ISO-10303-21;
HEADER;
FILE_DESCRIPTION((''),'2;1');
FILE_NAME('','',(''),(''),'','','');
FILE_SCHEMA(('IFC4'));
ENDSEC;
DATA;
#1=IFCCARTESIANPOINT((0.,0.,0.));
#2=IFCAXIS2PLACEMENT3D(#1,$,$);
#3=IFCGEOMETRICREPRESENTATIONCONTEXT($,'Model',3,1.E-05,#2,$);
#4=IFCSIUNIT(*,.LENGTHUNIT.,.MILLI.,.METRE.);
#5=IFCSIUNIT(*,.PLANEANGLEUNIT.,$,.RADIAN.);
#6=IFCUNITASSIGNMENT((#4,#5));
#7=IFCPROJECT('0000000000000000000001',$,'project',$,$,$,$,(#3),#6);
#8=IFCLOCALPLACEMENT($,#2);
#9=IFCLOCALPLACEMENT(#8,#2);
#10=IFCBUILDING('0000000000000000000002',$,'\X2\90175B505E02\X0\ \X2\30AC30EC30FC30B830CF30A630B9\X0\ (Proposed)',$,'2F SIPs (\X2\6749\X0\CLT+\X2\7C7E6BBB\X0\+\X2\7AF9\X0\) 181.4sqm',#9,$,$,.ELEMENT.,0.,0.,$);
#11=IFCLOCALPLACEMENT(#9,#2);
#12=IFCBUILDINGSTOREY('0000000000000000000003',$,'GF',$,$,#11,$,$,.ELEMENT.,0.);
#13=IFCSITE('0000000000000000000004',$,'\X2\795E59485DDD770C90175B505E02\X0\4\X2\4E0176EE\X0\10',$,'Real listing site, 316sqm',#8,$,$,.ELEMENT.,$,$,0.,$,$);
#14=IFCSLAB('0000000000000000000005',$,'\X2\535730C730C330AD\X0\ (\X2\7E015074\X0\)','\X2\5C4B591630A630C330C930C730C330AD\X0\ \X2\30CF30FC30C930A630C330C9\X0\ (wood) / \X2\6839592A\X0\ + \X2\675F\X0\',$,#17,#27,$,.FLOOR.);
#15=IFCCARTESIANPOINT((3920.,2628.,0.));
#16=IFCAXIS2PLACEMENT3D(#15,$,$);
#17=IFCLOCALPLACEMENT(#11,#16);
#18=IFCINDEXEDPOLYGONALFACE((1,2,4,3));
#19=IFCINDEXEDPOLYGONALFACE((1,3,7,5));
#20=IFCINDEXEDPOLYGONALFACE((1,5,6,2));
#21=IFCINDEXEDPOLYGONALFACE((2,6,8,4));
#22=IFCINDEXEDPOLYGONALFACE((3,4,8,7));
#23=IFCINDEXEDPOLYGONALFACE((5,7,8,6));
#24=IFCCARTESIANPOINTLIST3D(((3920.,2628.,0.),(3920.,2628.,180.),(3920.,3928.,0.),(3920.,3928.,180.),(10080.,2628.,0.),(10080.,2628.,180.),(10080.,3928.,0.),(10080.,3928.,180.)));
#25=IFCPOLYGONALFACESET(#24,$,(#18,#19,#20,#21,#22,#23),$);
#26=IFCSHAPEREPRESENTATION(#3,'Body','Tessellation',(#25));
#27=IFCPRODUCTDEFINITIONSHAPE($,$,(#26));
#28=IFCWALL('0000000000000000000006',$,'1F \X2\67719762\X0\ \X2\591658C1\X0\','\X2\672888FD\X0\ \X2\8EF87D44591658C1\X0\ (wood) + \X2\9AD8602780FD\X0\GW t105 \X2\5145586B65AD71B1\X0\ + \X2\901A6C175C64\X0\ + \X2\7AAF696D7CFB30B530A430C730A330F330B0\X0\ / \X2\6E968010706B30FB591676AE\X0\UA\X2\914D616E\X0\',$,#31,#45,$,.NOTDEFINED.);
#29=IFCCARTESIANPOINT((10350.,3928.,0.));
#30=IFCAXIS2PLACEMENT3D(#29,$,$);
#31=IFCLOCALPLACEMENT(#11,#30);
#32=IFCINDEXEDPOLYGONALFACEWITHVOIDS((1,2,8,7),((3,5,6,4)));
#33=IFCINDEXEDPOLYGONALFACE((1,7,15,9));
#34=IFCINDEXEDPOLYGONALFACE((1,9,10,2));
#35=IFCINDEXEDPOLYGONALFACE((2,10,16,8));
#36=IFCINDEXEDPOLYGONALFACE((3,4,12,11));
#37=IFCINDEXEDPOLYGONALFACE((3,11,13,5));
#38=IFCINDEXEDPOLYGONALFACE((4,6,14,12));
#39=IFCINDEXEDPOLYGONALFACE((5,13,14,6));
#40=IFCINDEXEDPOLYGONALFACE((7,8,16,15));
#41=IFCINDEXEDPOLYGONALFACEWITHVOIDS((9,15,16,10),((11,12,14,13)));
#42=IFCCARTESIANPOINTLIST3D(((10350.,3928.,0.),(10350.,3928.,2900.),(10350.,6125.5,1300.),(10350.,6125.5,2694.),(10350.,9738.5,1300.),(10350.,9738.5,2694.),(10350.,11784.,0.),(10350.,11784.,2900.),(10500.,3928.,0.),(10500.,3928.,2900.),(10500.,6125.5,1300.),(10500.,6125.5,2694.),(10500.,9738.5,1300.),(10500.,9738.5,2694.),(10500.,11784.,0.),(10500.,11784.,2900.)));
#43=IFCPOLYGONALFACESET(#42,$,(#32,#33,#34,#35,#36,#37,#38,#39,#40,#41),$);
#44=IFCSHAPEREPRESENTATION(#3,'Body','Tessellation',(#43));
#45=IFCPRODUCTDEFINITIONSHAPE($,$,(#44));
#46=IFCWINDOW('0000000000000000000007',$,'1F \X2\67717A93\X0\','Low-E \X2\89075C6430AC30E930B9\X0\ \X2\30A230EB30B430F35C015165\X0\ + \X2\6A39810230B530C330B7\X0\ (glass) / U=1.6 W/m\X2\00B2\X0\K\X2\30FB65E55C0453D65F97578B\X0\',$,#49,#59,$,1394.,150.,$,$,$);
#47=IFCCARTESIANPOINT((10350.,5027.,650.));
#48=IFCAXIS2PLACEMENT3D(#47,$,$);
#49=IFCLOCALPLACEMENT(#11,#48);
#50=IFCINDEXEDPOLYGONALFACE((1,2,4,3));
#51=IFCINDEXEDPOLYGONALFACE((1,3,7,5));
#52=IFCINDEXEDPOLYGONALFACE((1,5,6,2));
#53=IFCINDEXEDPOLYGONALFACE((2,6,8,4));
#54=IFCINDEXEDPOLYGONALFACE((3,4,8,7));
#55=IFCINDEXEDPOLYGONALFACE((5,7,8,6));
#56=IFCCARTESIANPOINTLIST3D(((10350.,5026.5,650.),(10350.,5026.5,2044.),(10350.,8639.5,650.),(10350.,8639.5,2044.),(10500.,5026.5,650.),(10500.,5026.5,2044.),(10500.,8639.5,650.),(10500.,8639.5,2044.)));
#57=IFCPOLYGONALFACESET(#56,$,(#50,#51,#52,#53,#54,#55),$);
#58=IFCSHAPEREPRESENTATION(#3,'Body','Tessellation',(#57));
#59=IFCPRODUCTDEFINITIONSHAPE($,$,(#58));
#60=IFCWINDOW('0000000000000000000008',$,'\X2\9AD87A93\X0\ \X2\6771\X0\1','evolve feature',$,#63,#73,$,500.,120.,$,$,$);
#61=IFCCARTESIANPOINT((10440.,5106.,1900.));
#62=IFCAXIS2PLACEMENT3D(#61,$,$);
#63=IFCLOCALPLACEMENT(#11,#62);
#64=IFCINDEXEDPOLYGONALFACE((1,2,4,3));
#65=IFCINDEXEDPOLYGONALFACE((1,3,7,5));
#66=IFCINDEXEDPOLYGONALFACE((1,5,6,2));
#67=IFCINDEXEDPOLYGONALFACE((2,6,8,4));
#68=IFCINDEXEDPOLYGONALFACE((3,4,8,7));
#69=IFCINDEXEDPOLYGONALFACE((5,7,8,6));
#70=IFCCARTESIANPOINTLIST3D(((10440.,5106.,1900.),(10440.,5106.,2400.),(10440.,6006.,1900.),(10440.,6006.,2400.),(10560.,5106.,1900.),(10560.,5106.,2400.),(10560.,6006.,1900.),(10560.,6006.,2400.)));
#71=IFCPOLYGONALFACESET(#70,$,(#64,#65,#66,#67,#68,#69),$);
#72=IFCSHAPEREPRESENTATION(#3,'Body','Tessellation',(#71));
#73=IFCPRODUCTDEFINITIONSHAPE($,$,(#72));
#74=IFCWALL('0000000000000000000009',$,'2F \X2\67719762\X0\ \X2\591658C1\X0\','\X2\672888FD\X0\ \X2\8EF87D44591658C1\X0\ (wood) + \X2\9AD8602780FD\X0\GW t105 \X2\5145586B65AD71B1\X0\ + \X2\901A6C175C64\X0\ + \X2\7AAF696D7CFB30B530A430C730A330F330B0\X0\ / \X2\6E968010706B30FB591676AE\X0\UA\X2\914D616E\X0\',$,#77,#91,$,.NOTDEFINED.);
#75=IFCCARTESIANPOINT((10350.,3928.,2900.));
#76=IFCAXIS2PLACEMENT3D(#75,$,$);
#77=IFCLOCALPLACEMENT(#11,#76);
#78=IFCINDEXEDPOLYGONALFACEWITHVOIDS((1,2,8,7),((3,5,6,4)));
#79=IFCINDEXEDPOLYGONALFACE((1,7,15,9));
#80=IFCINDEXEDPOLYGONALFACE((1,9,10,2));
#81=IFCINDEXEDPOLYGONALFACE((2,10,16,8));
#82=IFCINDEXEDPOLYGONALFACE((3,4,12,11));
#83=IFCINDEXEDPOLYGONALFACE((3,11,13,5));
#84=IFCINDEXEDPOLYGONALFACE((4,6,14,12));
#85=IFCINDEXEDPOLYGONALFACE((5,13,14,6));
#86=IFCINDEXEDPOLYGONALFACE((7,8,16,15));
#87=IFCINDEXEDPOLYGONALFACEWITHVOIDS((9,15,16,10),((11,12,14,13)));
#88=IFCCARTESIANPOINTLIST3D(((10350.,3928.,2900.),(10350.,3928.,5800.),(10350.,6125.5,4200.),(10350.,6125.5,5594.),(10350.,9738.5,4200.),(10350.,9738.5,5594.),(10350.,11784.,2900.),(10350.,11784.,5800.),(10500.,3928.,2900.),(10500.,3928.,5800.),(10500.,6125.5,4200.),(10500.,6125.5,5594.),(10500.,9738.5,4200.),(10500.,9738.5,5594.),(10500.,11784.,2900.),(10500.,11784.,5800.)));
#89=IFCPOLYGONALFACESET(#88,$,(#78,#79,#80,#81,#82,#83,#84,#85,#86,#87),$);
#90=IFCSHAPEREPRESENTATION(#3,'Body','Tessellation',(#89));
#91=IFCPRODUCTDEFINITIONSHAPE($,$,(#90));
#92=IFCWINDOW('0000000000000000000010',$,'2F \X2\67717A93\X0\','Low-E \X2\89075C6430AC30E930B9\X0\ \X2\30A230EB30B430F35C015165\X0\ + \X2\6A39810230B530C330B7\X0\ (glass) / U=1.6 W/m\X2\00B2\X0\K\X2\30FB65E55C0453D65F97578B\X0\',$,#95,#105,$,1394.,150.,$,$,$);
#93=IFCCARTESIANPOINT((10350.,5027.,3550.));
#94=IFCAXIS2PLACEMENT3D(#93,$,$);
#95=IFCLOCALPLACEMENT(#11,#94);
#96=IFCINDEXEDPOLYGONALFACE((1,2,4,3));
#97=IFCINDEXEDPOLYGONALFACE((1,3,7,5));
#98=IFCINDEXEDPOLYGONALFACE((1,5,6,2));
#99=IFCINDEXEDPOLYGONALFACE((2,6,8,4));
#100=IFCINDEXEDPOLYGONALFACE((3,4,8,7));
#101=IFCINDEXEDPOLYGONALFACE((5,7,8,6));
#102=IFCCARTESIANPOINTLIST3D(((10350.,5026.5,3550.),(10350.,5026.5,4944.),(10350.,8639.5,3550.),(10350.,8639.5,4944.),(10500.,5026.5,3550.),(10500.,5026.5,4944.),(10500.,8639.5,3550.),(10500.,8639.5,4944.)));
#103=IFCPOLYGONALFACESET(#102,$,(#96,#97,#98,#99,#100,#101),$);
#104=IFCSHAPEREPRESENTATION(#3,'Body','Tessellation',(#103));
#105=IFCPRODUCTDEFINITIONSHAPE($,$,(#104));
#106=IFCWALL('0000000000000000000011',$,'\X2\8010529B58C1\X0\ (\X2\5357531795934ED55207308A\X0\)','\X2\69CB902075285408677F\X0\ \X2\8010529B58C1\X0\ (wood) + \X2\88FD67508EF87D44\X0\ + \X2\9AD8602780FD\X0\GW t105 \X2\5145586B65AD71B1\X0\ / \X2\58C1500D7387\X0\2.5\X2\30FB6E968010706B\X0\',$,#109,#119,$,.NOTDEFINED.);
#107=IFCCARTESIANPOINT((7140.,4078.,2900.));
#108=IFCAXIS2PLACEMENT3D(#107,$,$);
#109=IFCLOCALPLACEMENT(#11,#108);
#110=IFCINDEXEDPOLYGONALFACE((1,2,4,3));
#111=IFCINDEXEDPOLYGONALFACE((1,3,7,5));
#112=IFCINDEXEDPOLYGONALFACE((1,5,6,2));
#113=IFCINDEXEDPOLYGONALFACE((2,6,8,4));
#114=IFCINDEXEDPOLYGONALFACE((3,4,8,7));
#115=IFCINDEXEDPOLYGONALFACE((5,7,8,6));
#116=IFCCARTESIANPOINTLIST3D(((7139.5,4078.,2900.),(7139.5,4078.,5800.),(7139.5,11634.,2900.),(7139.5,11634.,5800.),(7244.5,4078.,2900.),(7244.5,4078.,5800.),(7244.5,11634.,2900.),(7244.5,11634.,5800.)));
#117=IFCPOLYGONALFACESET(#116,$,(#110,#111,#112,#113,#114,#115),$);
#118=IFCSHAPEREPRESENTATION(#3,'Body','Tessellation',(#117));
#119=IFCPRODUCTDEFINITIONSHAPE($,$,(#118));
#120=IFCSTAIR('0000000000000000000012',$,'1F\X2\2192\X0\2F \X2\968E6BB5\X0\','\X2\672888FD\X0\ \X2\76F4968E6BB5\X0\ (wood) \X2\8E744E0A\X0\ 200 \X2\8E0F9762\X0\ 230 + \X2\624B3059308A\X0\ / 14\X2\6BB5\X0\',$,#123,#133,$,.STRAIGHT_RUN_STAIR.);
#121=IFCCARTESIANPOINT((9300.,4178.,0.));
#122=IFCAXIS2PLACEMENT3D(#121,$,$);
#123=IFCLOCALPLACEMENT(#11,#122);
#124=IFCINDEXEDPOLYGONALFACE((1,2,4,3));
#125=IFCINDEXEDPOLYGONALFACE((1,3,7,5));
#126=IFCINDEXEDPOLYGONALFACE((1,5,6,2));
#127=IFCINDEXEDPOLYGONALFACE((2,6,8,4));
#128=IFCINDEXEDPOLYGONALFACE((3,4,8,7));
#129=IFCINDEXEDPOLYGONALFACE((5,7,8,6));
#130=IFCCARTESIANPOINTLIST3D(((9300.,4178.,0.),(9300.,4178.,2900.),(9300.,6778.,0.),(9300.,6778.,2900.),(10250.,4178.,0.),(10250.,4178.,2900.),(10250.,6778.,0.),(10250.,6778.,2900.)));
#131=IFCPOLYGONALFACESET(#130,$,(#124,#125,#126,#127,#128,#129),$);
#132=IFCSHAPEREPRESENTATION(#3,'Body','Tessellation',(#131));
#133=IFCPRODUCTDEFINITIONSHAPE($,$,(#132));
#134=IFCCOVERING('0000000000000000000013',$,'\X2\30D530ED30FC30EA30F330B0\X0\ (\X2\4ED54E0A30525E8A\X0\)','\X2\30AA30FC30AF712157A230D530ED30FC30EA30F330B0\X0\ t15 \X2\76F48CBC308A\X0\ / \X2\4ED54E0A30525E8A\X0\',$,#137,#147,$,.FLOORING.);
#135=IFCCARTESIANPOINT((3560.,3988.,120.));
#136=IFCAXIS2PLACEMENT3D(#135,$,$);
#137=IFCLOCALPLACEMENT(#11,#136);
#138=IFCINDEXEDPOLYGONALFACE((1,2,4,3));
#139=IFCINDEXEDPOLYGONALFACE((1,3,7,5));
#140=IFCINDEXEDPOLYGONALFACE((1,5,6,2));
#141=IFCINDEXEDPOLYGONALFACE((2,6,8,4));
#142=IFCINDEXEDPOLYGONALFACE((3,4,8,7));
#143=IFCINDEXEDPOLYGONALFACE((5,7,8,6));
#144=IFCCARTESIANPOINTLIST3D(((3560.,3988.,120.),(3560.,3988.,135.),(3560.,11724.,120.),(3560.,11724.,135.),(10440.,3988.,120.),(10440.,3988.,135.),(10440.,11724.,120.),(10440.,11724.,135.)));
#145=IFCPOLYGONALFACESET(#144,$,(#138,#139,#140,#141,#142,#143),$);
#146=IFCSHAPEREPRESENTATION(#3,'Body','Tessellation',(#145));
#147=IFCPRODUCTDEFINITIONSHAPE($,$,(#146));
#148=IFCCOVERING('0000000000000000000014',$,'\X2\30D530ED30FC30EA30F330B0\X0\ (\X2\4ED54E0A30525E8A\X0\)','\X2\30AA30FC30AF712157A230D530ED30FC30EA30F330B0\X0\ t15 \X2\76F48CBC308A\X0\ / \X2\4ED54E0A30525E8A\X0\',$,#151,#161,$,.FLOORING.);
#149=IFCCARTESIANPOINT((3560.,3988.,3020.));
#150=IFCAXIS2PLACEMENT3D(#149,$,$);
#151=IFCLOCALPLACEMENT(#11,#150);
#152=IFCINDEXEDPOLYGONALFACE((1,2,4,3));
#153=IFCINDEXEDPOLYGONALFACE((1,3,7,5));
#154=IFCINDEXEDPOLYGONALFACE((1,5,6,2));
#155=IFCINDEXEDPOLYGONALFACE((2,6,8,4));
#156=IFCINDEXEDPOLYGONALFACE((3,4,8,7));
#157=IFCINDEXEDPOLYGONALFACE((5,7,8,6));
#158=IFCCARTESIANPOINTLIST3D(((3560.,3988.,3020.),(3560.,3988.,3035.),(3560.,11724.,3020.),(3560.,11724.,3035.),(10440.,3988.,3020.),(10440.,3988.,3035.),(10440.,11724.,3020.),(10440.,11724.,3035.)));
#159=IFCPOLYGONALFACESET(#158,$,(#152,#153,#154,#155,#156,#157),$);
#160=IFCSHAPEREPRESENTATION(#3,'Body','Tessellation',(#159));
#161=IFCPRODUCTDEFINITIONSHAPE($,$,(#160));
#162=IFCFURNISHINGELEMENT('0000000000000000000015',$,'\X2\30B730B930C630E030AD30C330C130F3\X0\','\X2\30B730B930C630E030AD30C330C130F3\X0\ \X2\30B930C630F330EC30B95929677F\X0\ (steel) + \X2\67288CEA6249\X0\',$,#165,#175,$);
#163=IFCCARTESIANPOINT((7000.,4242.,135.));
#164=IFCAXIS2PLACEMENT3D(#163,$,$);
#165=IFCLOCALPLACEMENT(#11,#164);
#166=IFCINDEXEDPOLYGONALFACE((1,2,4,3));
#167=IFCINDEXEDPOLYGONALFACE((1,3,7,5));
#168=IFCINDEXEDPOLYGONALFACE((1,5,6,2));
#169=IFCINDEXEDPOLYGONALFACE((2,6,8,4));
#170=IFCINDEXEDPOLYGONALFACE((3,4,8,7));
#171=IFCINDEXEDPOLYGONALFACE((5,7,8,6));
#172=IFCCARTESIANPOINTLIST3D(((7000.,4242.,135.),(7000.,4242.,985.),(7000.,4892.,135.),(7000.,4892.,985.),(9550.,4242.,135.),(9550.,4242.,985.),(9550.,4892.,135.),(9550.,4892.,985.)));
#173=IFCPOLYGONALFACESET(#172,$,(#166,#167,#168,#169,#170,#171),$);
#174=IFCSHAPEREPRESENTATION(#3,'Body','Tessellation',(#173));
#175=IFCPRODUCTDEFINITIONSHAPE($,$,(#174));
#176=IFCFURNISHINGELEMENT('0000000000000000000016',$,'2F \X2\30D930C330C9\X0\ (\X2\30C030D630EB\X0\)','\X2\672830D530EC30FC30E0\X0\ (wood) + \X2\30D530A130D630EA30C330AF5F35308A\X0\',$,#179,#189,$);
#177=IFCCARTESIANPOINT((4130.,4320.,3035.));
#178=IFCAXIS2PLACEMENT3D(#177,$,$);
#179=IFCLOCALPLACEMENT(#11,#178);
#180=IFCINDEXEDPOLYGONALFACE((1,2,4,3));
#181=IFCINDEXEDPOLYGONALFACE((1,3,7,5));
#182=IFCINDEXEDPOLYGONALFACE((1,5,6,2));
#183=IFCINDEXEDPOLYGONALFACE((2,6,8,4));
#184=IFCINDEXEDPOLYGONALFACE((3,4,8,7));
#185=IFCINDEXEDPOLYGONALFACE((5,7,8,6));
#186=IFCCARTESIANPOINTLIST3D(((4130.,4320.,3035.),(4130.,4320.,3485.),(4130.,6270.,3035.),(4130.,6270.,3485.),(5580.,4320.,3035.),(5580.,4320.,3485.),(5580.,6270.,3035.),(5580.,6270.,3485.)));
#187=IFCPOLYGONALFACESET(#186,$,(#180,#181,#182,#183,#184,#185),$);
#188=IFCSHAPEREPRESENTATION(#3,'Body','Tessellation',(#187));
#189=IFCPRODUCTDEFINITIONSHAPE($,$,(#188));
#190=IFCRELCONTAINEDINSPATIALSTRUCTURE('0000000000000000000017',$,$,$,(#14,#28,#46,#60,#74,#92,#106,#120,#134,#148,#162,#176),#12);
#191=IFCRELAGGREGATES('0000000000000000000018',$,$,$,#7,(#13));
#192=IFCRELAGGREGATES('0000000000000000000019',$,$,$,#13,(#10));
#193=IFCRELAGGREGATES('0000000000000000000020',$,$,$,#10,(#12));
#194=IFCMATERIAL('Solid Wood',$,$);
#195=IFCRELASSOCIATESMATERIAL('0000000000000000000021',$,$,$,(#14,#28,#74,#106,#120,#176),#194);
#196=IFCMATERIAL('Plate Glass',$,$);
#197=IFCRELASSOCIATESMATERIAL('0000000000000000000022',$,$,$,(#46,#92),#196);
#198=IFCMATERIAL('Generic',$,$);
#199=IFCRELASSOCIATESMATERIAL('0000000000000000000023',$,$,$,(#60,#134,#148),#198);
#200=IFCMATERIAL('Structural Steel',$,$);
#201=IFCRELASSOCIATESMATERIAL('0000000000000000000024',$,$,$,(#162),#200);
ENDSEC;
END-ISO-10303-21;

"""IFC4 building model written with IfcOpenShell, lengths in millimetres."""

from ifc_helpers import new_model, si_unit, frame, frame_2d, origin, place, context, project, spatial, rectangle, extrude, material, element, fill, save


model = new_model("IFC4")

# Units and contexts
model_context = context("Model", 3, precision=1e-05, world=origin())
ifc_project = project(units=[si_unit("LENGTHUNIT", "METRE", prefix="MILLI"), si_unit("PLANEANGLEUNIT", "RADIAN")], contexts=[model_context])

# Site, building, storey
site_placement = place(None, origin())
site = spatial("IfcSite", under=ifc_project, at=site_placement, Name="神奈川県逗子市4丁目10", ObjectType="Real listing site, 316sqm", CompositionType="ELEMENT", RefElevation=0.0)
building_placement = place(site_placement, origin())
building = spatial("IfcBuilding", under=site, at=building_placement, Name="逗子市 ガレージハウス (Proposed)", ObjectType="2F SIPs (杉CLT+籾殻+竹) 181.4sqm", CompositionType="ELEMENT", ElevationOfRefHeight=0.0, ElevationOfTerrain=0.0)
storey_placement = place(building_placement, origin())
storey = spatial("IfcBuildingStorey", under=building, at=storey_placement, Name="GF", CompositionType="ELEMENT", Elevation=0.0)

# Slab
ifc_material_1 = material(Name="Solid Wood")
slab_placement = place(storey_placement, frame((3920.0, 2628.0, 0.0)))
element("IfcSlab", 1, at=slab_placement, inside=storey, material=ifc_material_1, Name="南デッキ (縁側)", Description="屋外ウッドデッキ ハードウッド (wood) / 根太 + 束", PredefinedType="FLOOR", context=model_context, shape_type="SweptSolid", body=[
    extrude(rectangle(XDim=6160.0, YDim=1300.0, at=frame_2d((3080.0, 650.0))), frame((3920.0, 2628.0, 0.0)), (0.0, 0.0, 1.0), 180.0),
])

# Wall, openings, windows
wall_1_placement = place(storey_placement, frame((10350.0, 3928.0, 0.0)))
wall_1 = element("IfcWall", 2, at=wall_1_placement, inside=storey, material=ifc_material_1, Name="1F 東面 外壁", Description="木製 軸組外壁 (wood) + 高性能GW t105 充填断熱 + 通気層 + 窯業系サイディング / 準耐火・外皮UA配慮", PredefinedType="NOTDEFINED", context=model_context, shape_type="SweptSolid", body=[
    extrude(rectangle(XDim=150.0, YDim=7856.0, at=frame_2d((75.0, 3928.0))), frame((10350.0, 3928.0, 0.0)), (0.0, 0.0, 1.0), 2900.0),
])
opening_1_placement = place(storey_placement, frame((10350.0, 5027.0, 650.0)))
opening_1 = element("IfcOpeningElement", 3, at=opening_1_placement, cuts=wall_1, PredefinedType="NOTDEFINED", context=model_context, shape_type="SweptSolid", body=[
    extrude(rectangle(XDim=150.0, YDim=3613.0, at=frame_2d((75.0, 1806.0))), frame((10350.0, 5027.0, 650.0)), (0.0, 0.0, 1.0), 1394.0),
])
opening_2_placement = place(storey_placement, frame((10440.0, 5106.0, 1900.0)))
opening_2 = element("IfcOpeningElement", 4, at=opening_2_placement, cuts=wall_1, PredefinedType="NOTDEFINED", context=model_context, shape_type="SweptSolid", body=[
    extrude(rectangle(XDim=120.0, YDim=900.0, at=frame_2d((60.0, 450.0))), frame((10440.0, 5106.0, 1900.0)), (0.0, 0.0, 1.0), 500.0),
])
ifc_material_2 = material(Name="Plate Glass")
window_1_placement = place(storey_placement, frame((10350.0, 5027.0, 650.0)))
window_1 = element("IfcWindow", 5, at=window_1_placement, inside=storey, material=ifc_material_2, Name="1F 東窓", Description="Low-E 複層ガラス アルゴン封入 + 樹脂サッシ (glass) / U=1.6 W/m²K・日射取得型", OverallHeight=1394.0, OverallWidth=150.0, context=model_context, shape_type="SweptSolid", body=[
    extrude(rectangle(XDim=150.0, YDim=3613.0, at=frame_2d((75.0, 1806.0))), frame((10350.0, 5027.0, 650.0)), (0.0, 0.0, 1.0), 1394.0),
])
fill(opening_1, window_1)
ifc_material_3 = material(Name="Generic")
window_2_placement = place(storey_placement, frame((10440.0, 5106.0, 1900.0)))
window_2 = element("IfcWindow", 6, at=window_2_placement, inside=storey, material=ifc_material_3, Name="高窓 東1", Description="evolve feature", OverallHeight=500.0, OverallWidth=120.0, context=model_context, shape_type="SweptSolid", body=[
    extrude(rectangle(XDim=120.0, YDim=900.0, at=frame_2d((60.0, 450.0))), frame((10440.0, 5106.0, 1900.0)), (0.0, 0.0, 1.0), 500.0),
])
fill(opening_2, window_2)

# Wall, opening, window
wall_2_placement = place(storey_placement, frame((10350.0, 3928.0, 2900.0)))
wall_2 = element("IfcWall", 7, at=wall_2_placement, inside=storey, material=ifc_material_1, Name="2F 東面 外壁", Description="木製 軸組外壁 (wood) + 高性能GW t105 充填断熱 + 通気層 + 窯業系サイディング / 準耐火・外皮UA配慮", PredefinedType="NOTDEFINED", context=model_context, shape_type="SweptSolid", body=[
    extrude(rectangle(XDim=150.0, YDim=7856.0, at=frame_2d((75.0, 3928.0))), frame((10350.0, 3928.0, 2900.0)), (0.0, 0.0, 1.0), 2900.0),
])
opening_3_placement = place(storey_placement, frame((10350.0, 5027.0, 3550.0)))
opening_3 = element("IfcOpeningElement", 8, at=opening_3_placement, cuts=wall_2, PredefinedType="NOTDEFINED", context=model_context, shape_type="SweptSolid", body=[
    extrude(rectangle(XDim=150.0, YDim=3613.0, at=frame_2d((75.0, 1806.0))), frame((10350.0, 5027.0, 3550.0)), (0.0, 0.0, 1.0), 1394.0),
])
window_3_placement = place(storey_placement, frame((10350.0, 5027.0, 3550.0)))
window_3 = element("IfcWindow", 9, at=window_3_placement, inside=storey, material=ifc_material_2, Name="2F 東窓", Description="Low-E 複層ガラス アルゴン封入 + 樹脂サッシ (glass) / U=1.6 W/m²K・日射取得型", OverallHeight=1394.0, OverallWidth=150.0, context=model_context, shape_type="SweptSolid", body=[
    extrude(rectangle(XDim=150.0, YDim=3613.0, at=frame_2d((75.0, 1806.0))), frame((10350.0, 5027.0, 3550.0)), (0.0, 0.0, 1.0), 1394.0),
])
fill(opening_3, window_3)

# Wall
wall_3_placement = place(storey_placement, frame((7140.0, 4078.0, 2900.0)))
element("IfcWall", 10, at=wall_3_placement, inside=storey, material=ifc_material_1, Name="耐力壁 (南北間仕切り)", Description="構造用合板 耐力壁 (wood) + 製材軸組 + 高性能GW t105 充填断熱 / 壁倍率2.5・準耐火", PredefinedType="NOTDEFINED", context=model_context, shape_type="SweptSolid", body=[
    extrude(rectangle(XDim=105.0, YDim=7556.0, at=frame_2d((52.0, 3778.0))), frame((7140.0, 4078.0, 2900.0)), (0.0, 0.0, 1.0), 2900.0),
])

# Stair
stair_placement = place(storey_placement, frame((9300.0, 4178.0, 0.0)))
element("IfcStair", 11, at=stair_placement, inside=storey, material=ifc_material_1, Name="1F→2F 階段", Description="木製 直階段 (wood) 蹴上 200 踏面 230 + 手すり / 14段", PredefinedType="STRAIGHT_RUN_STAIR", context=model_context, shape_type="SweptSolid", body=[
    extrude(rectangle(XDim=950.0, YDim=2600.0, at=frame_2d((475.0, 1300.0))), frame((9300.0, 4178.0, 0.0)), (0.0, 0.0, 1.0), 2900.0),
])

# Coverings
covering_1_placement = place(storey_placement, frame((3560.0, 3988.0, 120.0)))
element("IfcCovering", 12, at=covering_1_placement, inside=storey, material=ifc_material_3, Name="フローリング (仕上げ床)", Description="オーク無垢フローリング t15 直貼り / 仕上げ床", PredefinedType="FLOORING", context=model_context, shape_type="SweptSolid", body=[
    extrude(rectangle(XDim=6880.0, YDim=7736.0, at=frame_2d((3440.0, 3868.0))), frame((3560.0, 3988.0, 120.0)), (0.0, 0.0, 1.0), 15.0),
])
covering_2_placement = place(storey_placement, frame((3560.0, 3988.0, 3020.0)))
element("IfcCovering", 13, at=covering_2_placement, inside=storey, material=ifc_material_3, Name="フローリング (仕上げ床)", Description="オーク無垢フローリング t15 直貼り / 仕上げ床", PredefinedType="FLOORING", context=model_context, shape_type="SweptSolid", body=[
    extrude(rectangle(XDim=6880.0, YDim=7736.0, at=frame_2d((3440.0, 3868.0))), frame((3560.0, 3988.0, 3020.0)), (0.0, 0.0, 1.0), 15.0),
])

# Furnishing elements
ifc_material_4 = material(Name="Structural Steel")
furnishing_1_placement = place(storey_placement, frame((7000.0, 4242.0, 135.0)))
element("IfcFurnishingElement", 14, at=furnishing_1_placement, inside=storey, material=ifc_material_4, Name="システムキッチン", Description="システムキッチン ステンレス天板 (steel) + 木質扉", context=model_context, shape_type="SweptSolid", body=[
    extrude(rectangle(XDim=2550.0, YDim=650.0, at=frame_2d((1275.0, 325.0))), frame((7000.0, 4242.0, 135.0)), (0.0, 0.0, 1.0), 850.0),
])
furnishing_2_placement = place(storey_placement, frame((4130.0, 4320.0, 3035.0)))
element("IfcFurnishingElement", 15, at=furnishing_2_placement, inside=storey, material=ifc_material_1, Name="2F ベッド (ダブル)", Description="木フレーム (wood) + ファブリック張り", context=model_context, shape_type="SweptSolid", body=[
    extrude(rectangle(XDim=1450.0, YDim=1950.0, at=frame_2d((725.0, 975.0))), frame((4130.0, 4320.0, 3035.0)), (0.0, 0.0, 1.0), 450.0),
])

save(model, "model.ifc")
